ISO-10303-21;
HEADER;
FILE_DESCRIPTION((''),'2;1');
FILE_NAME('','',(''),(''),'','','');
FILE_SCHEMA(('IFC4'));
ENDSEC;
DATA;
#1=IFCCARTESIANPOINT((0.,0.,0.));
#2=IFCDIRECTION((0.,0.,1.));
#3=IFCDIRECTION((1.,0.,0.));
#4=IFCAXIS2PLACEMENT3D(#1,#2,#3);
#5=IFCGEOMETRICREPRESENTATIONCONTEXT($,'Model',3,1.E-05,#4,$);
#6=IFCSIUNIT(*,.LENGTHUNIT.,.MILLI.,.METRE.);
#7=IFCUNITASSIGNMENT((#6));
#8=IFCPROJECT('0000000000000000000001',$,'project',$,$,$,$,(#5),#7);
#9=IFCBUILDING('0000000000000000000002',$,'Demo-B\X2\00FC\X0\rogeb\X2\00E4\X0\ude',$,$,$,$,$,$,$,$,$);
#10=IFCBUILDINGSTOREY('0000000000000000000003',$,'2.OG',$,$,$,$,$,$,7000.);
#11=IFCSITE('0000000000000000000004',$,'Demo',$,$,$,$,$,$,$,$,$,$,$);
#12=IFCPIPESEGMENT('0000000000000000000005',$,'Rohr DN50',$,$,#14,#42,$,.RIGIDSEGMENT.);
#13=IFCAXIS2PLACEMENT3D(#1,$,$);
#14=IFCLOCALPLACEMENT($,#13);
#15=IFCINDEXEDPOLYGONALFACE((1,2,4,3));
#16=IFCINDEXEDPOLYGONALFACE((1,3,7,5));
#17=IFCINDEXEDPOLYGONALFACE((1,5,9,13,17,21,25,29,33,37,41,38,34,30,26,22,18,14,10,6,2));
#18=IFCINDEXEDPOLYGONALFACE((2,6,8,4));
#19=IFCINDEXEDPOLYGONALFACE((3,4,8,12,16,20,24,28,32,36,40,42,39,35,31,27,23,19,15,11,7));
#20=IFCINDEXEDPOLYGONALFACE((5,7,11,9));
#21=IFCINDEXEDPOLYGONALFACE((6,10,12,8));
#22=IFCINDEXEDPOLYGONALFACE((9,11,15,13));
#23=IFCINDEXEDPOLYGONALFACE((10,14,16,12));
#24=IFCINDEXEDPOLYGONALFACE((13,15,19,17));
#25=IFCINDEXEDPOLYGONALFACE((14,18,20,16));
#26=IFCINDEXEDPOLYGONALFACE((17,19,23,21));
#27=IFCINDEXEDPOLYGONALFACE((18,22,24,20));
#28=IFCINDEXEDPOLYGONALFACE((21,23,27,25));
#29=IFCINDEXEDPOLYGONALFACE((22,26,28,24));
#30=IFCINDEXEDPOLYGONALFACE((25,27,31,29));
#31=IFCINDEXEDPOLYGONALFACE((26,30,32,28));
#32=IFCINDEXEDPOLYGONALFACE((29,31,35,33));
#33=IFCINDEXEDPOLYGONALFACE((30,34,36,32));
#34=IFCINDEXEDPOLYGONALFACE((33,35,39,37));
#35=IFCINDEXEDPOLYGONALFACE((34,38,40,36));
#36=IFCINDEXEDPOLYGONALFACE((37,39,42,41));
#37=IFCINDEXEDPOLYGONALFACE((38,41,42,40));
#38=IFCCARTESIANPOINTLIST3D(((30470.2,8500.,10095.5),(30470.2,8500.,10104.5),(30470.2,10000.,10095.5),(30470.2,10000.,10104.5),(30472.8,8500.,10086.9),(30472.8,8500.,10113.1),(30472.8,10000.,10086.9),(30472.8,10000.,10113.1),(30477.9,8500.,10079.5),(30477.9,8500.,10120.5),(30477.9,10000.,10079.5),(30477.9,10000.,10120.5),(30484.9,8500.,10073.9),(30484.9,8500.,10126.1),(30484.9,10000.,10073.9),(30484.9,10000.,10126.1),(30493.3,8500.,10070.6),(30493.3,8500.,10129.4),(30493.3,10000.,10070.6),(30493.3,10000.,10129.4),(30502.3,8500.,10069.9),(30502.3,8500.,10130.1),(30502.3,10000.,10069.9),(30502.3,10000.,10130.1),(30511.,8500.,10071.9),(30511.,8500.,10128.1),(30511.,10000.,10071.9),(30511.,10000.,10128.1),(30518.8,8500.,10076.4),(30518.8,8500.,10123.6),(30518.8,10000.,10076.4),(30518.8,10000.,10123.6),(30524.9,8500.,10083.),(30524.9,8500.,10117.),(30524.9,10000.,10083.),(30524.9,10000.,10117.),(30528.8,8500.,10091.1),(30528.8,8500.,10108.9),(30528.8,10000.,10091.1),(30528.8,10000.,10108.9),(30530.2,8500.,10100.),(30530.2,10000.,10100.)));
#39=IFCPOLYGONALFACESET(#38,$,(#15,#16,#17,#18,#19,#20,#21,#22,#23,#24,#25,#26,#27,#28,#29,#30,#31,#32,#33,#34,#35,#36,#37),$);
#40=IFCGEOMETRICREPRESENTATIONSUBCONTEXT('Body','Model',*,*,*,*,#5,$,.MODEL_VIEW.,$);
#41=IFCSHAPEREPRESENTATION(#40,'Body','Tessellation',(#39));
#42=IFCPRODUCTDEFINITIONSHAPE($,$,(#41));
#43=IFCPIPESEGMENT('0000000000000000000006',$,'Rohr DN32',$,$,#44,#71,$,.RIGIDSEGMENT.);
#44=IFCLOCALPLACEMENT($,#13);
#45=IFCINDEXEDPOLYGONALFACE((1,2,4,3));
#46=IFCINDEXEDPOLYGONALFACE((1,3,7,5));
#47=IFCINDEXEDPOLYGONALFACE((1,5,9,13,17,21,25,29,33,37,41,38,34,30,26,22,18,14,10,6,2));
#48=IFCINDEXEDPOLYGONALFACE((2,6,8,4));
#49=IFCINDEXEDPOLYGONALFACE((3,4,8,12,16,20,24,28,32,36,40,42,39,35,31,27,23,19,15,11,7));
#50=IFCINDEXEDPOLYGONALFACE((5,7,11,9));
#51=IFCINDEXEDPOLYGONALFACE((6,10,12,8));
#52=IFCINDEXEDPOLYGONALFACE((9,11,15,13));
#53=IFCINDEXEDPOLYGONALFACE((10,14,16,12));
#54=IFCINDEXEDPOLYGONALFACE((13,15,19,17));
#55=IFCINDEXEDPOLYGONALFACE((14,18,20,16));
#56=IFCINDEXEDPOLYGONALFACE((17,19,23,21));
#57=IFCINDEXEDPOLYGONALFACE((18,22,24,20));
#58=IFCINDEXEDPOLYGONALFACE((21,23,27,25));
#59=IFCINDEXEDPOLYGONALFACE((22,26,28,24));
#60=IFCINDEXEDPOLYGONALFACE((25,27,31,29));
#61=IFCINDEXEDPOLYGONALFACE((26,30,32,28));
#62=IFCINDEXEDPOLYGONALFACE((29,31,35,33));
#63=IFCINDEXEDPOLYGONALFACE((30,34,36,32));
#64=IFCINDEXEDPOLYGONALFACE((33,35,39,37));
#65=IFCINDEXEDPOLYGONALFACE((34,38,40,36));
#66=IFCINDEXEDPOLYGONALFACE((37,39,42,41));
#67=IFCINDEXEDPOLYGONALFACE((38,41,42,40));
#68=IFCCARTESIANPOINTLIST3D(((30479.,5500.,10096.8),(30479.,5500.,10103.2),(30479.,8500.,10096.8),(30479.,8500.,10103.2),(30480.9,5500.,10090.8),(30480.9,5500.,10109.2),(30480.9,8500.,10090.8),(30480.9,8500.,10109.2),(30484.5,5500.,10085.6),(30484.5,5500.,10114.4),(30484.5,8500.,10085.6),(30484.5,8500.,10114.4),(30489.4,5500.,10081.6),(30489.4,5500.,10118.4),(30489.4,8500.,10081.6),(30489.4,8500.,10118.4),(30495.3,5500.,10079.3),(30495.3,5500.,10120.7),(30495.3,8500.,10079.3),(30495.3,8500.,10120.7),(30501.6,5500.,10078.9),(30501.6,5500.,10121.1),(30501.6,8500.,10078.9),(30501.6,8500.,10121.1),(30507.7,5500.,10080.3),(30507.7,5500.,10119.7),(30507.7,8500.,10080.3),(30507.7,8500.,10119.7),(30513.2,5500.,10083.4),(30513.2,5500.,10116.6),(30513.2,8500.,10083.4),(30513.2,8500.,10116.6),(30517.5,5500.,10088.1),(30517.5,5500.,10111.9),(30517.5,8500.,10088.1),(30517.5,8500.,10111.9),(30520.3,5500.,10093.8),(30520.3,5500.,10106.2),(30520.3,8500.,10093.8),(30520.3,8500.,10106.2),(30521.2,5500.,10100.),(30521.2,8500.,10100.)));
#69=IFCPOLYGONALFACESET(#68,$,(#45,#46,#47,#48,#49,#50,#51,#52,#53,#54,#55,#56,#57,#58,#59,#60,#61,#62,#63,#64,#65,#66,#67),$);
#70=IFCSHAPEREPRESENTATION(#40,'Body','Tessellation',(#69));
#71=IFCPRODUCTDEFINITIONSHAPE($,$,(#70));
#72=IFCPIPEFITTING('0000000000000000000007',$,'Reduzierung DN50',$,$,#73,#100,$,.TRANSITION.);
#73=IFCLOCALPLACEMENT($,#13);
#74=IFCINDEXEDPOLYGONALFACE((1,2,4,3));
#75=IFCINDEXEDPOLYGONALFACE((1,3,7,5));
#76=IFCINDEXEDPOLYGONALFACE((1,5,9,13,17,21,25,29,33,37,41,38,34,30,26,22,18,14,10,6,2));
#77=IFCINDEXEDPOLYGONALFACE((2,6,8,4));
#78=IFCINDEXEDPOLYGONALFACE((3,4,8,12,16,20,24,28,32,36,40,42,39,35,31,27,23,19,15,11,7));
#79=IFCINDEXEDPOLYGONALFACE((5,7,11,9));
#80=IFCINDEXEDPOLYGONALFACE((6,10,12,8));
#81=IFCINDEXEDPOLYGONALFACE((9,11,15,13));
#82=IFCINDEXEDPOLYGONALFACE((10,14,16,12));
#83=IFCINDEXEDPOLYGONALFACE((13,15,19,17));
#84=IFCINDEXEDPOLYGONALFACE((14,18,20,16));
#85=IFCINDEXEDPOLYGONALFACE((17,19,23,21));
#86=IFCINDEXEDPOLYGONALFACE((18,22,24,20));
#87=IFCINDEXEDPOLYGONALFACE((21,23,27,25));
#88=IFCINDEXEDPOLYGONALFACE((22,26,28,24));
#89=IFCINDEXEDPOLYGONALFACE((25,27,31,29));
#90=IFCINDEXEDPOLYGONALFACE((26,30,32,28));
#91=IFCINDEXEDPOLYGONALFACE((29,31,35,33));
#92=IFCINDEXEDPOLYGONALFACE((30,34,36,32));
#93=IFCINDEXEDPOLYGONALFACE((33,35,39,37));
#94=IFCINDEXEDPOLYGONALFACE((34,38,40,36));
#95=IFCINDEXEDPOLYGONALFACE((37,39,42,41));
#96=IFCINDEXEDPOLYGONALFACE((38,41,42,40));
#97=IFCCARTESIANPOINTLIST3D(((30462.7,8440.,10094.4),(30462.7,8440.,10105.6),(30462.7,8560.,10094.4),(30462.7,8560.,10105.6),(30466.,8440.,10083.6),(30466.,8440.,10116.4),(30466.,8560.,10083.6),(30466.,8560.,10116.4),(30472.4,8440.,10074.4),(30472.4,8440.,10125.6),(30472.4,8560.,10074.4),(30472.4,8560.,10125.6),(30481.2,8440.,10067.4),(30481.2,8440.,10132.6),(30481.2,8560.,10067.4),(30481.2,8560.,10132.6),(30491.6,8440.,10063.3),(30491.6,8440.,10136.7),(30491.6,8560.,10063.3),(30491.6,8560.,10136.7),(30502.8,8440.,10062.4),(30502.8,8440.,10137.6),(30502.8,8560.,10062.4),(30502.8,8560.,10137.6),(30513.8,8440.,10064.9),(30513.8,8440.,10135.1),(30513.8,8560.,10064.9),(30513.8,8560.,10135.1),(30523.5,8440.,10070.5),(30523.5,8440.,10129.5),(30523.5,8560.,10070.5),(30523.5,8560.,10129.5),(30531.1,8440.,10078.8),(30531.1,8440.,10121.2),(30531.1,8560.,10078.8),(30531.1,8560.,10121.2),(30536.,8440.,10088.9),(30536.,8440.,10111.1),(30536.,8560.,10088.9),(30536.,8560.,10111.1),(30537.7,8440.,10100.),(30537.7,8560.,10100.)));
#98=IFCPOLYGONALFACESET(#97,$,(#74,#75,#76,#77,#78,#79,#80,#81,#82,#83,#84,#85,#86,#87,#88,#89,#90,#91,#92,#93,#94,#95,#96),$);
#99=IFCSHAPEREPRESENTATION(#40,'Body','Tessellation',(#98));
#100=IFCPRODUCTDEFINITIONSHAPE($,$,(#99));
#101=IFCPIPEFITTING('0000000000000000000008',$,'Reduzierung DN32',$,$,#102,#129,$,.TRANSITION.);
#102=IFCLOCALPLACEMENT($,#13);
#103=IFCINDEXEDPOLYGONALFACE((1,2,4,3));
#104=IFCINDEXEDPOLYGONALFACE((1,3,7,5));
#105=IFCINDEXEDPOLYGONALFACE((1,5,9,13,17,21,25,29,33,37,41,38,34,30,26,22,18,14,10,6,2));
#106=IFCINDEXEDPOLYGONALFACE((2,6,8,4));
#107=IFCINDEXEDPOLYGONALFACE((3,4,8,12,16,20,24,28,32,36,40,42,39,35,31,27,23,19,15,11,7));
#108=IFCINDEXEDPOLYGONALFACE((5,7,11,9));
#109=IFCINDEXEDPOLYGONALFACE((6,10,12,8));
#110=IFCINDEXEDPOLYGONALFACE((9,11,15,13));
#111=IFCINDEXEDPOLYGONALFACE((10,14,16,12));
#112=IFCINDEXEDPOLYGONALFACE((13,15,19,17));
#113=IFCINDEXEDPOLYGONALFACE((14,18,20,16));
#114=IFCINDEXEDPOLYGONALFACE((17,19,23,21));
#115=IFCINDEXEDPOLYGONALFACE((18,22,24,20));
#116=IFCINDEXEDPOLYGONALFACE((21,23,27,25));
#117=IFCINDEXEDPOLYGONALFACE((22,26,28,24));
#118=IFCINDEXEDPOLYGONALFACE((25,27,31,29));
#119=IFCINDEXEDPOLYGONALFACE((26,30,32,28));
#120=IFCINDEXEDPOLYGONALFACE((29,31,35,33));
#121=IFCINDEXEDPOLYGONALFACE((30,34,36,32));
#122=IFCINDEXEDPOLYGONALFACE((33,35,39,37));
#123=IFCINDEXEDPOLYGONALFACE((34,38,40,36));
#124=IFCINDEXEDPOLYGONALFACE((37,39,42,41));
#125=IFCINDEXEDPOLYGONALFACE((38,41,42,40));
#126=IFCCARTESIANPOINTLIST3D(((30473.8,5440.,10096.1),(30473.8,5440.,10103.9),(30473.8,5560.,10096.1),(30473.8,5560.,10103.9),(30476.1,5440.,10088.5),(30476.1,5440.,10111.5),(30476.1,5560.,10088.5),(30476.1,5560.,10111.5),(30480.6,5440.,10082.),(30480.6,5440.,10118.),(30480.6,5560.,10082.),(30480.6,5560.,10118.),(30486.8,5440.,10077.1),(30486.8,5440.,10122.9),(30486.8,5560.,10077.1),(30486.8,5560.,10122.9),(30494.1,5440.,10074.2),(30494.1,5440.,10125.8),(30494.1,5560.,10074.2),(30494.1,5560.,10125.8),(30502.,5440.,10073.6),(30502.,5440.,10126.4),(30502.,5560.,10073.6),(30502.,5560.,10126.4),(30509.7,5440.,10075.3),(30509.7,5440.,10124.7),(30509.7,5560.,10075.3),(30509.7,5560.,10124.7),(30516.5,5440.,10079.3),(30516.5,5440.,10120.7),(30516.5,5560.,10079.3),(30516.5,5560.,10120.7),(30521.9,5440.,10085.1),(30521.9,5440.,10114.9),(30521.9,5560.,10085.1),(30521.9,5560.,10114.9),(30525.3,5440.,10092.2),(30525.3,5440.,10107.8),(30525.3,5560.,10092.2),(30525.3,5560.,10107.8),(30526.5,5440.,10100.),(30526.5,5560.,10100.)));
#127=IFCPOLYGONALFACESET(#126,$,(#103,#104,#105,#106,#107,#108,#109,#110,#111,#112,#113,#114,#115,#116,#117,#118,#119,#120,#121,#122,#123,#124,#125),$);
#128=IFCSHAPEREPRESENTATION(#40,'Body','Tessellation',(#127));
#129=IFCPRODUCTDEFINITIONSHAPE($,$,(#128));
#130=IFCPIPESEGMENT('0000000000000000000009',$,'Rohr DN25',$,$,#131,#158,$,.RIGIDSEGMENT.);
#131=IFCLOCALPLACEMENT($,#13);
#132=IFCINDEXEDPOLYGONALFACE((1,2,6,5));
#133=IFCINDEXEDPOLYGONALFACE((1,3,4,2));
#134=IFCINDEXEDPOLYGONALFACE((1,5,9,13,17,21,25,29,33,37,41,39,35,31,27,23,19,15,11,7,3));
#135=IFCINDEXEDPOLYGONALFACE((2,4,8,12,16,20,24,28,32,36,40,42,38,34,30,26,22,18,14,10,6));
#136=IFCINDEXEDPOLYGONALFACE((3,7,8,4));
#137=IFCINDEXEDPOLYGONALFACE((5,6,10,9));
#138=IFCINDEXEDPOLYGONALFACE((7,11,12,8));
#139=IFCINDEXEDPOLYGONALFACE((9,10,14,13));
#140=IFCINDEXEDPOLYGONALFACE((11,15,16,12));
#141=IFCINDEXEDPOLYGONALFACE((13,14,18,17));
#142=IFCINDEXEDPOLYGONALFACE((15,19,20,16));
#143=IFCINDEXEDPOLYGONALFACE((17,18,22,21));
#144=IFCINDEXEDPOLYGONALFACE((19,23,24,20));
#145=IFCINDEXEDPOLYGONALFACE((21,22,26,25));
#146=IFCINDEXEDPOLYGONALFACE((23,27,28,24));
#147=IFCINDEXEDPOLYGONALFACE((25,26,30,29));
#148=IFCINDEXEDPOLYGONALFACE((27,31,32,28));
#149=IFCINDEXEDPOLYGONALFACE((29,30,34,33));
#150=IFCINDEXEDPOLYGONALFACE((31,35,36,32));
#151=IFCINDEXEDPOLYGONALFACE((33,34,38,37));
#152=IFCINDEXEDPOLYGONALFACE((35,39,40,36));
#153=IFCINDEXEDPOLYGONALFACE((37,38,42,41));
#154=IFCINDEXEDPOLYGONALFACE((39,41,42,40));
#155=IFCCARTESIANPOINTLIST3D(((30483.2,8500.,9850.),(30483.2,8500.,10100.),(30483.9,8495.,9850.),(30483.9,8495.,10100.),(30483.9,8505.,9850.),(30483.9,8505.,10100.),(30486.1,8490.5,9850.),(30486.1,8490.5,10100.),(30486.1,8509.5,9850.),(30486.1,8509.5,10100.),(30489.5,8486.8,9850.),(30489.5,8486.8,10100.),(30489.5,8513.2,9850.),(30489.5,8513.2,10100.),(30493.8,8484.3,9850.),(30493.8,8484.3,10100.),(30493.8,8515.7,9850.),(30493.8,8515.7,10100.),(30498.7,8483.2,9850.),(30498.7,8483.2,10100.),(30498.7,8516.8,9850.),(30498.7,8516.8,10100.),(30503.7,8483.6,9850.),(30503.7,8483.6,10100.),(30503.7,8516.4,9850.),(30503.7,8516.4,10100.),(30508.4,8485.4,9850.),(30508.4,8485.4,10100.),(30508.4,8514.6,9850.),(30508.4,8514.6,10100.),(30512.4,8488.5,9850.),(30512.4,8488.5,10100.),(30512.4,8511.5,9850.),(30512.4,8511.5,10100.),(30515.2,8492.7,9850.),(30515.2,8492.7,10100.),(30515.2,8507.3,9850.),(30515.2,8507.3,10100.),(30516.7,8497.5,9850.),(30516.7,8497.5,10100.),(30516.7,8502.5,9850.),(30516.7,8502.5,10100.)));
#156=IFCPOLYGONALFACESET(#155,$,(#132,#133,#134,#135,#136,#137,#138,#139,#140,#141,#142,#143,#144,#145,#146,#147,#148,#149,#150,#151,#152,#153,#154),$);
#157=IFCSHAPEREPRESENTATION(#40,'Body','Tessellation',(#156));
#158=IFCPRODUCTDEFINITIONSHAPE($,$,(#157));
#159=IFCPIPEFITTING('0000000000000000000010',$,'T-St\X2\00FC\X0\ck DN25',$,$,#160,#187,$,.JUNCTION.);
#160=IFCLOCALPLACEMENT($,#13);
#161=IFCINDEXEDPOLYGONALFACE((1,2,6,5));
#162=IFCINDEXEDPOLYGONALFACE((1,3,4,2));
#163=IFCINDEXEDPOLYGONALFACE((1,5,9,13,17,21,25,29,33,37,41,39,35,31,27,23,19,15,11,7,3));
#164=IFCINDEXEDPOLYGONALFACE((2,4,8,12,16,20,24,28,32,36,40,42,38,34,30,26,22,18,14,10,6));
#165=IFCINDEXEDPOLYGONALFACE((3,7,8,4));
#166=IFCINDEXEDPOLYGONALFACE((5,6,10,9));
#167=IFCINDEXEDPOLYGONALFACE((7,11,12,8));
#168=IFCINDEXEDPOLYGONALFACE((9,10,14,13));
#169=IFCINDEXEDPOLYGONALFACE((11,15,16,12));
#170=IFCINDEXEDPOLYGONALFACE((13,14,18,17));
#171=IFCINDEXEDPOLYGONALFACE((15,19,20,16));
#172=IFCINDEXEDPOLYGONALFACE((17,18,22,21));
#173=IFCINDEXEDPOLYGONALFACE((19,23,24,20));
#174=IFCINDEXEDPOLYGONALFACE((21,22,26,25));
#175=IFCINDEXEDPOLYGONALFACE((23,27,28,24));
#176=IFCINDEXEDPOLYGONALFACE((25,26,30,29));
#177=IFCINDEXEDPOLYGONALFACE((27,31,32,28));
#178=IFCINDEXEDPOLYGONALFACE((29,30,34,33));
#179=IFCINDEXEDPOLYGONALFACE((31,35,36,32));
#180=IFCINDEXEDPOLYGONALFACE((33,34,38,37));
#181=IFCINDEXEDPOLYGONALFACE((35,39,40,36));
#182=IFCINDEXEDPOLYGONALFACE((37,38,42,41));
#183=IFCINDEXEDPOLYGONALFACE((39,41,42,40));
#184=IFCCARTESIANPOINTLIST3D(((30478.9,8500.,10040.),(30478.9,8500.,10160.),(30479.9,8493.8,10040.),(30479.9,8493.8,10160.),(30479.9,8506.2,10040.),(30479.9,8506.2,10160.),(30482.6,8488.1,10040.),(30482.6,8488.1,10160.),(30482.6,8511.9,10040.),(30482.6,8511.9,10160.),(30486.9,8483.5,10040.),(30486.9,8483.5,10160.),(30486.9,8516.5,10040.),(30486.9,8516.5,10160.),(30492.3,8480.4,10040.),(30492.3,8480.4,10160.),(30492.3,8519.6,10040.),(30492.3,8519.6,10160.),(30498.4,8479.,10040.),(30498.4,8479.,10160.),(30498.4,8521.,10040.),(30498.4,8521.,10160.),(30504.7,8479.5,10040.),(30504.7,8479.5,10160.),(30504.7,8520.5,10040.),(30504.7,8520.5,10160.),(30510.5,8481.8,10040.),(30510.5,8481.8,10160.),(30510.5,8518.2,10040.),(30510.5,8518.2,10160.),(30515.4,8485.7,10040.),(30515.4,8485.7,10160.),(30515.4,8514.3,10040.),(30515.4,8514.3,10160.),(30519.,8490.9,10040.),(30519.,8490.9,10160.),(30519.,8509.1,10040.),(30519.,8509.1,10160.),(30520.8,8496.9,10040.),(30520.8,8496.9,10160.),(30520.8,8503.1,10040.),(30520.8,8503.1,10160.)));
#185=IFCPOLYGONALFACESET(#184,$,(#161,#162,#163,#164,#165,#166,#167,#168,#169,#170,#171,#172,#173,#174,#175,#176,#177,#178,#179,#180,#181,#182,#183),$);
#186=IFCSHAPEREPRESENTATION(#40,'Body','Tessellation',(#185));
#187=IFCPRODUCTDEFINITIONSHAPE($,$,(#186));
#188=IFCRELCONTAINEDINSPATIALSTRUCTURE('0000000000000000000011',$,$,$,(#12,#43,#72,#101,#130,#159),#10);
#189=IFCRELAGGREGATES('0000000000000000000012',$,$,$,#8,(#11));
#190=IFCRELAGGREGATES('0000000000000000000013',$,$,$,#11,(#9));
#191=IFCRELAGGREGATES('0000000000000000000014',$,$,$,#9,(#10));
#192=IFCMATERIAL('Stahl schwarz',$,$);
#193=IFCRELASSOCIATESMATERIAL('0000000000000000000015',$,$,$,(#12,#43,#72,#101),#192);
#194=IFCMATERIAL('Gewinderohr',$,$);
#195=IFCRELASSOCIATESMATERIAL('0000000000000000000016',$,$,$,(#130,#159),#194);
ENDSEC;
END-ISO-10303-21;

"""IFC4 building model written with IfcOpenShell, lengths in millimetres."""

from ifc_helpers import new_model, si_unit, frame, origin_with_axes, place, context, subcontext, project, spatial, circle, extrude, material, element, save


model = new_model("IFC4")

# Units and contexts
model_context = context("Model", 3, precision=1e-05, world=origin_with_axes())
body_context = subcontext(model_context, "Body", "Model", "MODEL_VIEW")
ifc_project = project(units=[si_unit("LENGTHUNIT", "METRE", prefix="MILLI")], contexts=[model_context])

# Site, building, storey
site = spatial("IfcSite", under=ifc_project, Name="Demo")
building = spatial("IfcBuilding", under=site, Name="Demo-Bürogebäude")
storey = spatial("IfcBuildingStorey", under=building, Name="2.OG", Elevation=7000.0)

# Pipe segments
ifc_material_1 = material(Name="Stahl schwarz")
pipe_segment_1_placement = place(None, frame((30500.0, 10000.0, 10100.0), z_axis=(0.0, -1.0, 0.0), x_axis=(1.0, 0.0, 0.0)))
element("IfcPipeSegment", 1, at=pipe_segment_1_placement, inside=storey, material=ifc_material_1, Name="Rohr DN50", PredefinedType="RIGIDSEGMENT", context=body_context, shape_type="SweptSolid", body=[
    extrude(circle(Radius=30.1), origin_with_axes(), (0.0, 0.0, 1.0), 1500.0),
])
pipe_segment_2_placement = place(None, frame((30500.0, 8500.0, 10100.0), z_axis=(0.0, -1.0, 0.0), x_axis=(1.0, 0.0, 0.0)))
element("IfcPipeSegment", 2, at=pipe_segment_2_placement, inside=storey, material=ifc_material_1, Name="Rohr DN32", PredefinedType="RIGIDSEGMENT", context=body_context, shape_type="SweptSolid", body=[
    extrude(circle(Radius=21.2), origin_with_axes(), (0.0, 0.0, 1.0), 3000.0),
])

# Pipe fittings
pipe_fitting_1_placement = place(None, frame((30500.0, 8560.0, 10100.0), z_axis=(0.0, -1.0, 0.0), x_axis=(1.0, 0.0, 0.0)))
element("IfcPipeFitting", 3, at=pipe_fitting_1_placement, inside=storey, material=ifc_material_1, Name="Reduzierung DN50", PredefinedType="TRANSITION", context=body_context, shape_type="SweptSolid", body=[
    extrude(circle(Radius=37.7), origin_with_axes(), (0.0, 0.0, 1.0), 120.0),
])
pipe_fitting_2_placement = place(None, frame((30500.0, 5560.0, 10100.0), z_axis=(0.0, -1.0, 0.0), x_axis=(1.0, 0.0, 0.0)))
element("IfcPipeFitting", 4, at=pipe_fitting_2_placement, inside=storey, material=ifc_material_1, Name="Reduzierung DN32", PredefinedType="TRANSITION", context=body_context, shape_type="SweptSolid", body=[
    extrude(circle(Radius=26.5), origin_with_axes(), (0.0, 0.0, 1.0), 120.0),
])

# Pipe segment
ifc_material_2 = material(Name="Gewinderohr")
pipe_segment_3_placement = place(None, frame((30500.0, 8500.0, 10100.0), z_axis=(0.0, 0.0, -1.0), x_axis=(-1.0, 0.0, 0.0)))
element("IfcPipeSegment", 5, at=pipe_segment_3_placement, inside=storey, material=ifc_material_2, Name="Rohr DN25", PredefinedType="RIGIDSEGMENT", context=body_context, shape_type="SweptSolid", body=[
    extrude(circle(Radius=16.9), origin_with_axes(), (0.0, 0.0, 1.0), 250.0),
])

# Pipe fitting
pipe_fitting_3_placement = place(None, frame((30500.0, 8500.0, 10160.0), z_axis=(0.0, 0.0, -1.0), x_axis=(-1.0, 0.0, 0.0)))
element("IfcPipeFitting", 6, at=pipe_fitting_3_placement, inside=storey, material=ifc_material_2, Name="T-Stück DN25", PredefinedType="JUNCTION", context=body_context, shape_type="SweptSolid", body=[
    extrude(circle(Radius=21.1), origin_with_axes(), (0.0, 0.0, 1.0), 120.0),
])

save(model, "model.ifc")
